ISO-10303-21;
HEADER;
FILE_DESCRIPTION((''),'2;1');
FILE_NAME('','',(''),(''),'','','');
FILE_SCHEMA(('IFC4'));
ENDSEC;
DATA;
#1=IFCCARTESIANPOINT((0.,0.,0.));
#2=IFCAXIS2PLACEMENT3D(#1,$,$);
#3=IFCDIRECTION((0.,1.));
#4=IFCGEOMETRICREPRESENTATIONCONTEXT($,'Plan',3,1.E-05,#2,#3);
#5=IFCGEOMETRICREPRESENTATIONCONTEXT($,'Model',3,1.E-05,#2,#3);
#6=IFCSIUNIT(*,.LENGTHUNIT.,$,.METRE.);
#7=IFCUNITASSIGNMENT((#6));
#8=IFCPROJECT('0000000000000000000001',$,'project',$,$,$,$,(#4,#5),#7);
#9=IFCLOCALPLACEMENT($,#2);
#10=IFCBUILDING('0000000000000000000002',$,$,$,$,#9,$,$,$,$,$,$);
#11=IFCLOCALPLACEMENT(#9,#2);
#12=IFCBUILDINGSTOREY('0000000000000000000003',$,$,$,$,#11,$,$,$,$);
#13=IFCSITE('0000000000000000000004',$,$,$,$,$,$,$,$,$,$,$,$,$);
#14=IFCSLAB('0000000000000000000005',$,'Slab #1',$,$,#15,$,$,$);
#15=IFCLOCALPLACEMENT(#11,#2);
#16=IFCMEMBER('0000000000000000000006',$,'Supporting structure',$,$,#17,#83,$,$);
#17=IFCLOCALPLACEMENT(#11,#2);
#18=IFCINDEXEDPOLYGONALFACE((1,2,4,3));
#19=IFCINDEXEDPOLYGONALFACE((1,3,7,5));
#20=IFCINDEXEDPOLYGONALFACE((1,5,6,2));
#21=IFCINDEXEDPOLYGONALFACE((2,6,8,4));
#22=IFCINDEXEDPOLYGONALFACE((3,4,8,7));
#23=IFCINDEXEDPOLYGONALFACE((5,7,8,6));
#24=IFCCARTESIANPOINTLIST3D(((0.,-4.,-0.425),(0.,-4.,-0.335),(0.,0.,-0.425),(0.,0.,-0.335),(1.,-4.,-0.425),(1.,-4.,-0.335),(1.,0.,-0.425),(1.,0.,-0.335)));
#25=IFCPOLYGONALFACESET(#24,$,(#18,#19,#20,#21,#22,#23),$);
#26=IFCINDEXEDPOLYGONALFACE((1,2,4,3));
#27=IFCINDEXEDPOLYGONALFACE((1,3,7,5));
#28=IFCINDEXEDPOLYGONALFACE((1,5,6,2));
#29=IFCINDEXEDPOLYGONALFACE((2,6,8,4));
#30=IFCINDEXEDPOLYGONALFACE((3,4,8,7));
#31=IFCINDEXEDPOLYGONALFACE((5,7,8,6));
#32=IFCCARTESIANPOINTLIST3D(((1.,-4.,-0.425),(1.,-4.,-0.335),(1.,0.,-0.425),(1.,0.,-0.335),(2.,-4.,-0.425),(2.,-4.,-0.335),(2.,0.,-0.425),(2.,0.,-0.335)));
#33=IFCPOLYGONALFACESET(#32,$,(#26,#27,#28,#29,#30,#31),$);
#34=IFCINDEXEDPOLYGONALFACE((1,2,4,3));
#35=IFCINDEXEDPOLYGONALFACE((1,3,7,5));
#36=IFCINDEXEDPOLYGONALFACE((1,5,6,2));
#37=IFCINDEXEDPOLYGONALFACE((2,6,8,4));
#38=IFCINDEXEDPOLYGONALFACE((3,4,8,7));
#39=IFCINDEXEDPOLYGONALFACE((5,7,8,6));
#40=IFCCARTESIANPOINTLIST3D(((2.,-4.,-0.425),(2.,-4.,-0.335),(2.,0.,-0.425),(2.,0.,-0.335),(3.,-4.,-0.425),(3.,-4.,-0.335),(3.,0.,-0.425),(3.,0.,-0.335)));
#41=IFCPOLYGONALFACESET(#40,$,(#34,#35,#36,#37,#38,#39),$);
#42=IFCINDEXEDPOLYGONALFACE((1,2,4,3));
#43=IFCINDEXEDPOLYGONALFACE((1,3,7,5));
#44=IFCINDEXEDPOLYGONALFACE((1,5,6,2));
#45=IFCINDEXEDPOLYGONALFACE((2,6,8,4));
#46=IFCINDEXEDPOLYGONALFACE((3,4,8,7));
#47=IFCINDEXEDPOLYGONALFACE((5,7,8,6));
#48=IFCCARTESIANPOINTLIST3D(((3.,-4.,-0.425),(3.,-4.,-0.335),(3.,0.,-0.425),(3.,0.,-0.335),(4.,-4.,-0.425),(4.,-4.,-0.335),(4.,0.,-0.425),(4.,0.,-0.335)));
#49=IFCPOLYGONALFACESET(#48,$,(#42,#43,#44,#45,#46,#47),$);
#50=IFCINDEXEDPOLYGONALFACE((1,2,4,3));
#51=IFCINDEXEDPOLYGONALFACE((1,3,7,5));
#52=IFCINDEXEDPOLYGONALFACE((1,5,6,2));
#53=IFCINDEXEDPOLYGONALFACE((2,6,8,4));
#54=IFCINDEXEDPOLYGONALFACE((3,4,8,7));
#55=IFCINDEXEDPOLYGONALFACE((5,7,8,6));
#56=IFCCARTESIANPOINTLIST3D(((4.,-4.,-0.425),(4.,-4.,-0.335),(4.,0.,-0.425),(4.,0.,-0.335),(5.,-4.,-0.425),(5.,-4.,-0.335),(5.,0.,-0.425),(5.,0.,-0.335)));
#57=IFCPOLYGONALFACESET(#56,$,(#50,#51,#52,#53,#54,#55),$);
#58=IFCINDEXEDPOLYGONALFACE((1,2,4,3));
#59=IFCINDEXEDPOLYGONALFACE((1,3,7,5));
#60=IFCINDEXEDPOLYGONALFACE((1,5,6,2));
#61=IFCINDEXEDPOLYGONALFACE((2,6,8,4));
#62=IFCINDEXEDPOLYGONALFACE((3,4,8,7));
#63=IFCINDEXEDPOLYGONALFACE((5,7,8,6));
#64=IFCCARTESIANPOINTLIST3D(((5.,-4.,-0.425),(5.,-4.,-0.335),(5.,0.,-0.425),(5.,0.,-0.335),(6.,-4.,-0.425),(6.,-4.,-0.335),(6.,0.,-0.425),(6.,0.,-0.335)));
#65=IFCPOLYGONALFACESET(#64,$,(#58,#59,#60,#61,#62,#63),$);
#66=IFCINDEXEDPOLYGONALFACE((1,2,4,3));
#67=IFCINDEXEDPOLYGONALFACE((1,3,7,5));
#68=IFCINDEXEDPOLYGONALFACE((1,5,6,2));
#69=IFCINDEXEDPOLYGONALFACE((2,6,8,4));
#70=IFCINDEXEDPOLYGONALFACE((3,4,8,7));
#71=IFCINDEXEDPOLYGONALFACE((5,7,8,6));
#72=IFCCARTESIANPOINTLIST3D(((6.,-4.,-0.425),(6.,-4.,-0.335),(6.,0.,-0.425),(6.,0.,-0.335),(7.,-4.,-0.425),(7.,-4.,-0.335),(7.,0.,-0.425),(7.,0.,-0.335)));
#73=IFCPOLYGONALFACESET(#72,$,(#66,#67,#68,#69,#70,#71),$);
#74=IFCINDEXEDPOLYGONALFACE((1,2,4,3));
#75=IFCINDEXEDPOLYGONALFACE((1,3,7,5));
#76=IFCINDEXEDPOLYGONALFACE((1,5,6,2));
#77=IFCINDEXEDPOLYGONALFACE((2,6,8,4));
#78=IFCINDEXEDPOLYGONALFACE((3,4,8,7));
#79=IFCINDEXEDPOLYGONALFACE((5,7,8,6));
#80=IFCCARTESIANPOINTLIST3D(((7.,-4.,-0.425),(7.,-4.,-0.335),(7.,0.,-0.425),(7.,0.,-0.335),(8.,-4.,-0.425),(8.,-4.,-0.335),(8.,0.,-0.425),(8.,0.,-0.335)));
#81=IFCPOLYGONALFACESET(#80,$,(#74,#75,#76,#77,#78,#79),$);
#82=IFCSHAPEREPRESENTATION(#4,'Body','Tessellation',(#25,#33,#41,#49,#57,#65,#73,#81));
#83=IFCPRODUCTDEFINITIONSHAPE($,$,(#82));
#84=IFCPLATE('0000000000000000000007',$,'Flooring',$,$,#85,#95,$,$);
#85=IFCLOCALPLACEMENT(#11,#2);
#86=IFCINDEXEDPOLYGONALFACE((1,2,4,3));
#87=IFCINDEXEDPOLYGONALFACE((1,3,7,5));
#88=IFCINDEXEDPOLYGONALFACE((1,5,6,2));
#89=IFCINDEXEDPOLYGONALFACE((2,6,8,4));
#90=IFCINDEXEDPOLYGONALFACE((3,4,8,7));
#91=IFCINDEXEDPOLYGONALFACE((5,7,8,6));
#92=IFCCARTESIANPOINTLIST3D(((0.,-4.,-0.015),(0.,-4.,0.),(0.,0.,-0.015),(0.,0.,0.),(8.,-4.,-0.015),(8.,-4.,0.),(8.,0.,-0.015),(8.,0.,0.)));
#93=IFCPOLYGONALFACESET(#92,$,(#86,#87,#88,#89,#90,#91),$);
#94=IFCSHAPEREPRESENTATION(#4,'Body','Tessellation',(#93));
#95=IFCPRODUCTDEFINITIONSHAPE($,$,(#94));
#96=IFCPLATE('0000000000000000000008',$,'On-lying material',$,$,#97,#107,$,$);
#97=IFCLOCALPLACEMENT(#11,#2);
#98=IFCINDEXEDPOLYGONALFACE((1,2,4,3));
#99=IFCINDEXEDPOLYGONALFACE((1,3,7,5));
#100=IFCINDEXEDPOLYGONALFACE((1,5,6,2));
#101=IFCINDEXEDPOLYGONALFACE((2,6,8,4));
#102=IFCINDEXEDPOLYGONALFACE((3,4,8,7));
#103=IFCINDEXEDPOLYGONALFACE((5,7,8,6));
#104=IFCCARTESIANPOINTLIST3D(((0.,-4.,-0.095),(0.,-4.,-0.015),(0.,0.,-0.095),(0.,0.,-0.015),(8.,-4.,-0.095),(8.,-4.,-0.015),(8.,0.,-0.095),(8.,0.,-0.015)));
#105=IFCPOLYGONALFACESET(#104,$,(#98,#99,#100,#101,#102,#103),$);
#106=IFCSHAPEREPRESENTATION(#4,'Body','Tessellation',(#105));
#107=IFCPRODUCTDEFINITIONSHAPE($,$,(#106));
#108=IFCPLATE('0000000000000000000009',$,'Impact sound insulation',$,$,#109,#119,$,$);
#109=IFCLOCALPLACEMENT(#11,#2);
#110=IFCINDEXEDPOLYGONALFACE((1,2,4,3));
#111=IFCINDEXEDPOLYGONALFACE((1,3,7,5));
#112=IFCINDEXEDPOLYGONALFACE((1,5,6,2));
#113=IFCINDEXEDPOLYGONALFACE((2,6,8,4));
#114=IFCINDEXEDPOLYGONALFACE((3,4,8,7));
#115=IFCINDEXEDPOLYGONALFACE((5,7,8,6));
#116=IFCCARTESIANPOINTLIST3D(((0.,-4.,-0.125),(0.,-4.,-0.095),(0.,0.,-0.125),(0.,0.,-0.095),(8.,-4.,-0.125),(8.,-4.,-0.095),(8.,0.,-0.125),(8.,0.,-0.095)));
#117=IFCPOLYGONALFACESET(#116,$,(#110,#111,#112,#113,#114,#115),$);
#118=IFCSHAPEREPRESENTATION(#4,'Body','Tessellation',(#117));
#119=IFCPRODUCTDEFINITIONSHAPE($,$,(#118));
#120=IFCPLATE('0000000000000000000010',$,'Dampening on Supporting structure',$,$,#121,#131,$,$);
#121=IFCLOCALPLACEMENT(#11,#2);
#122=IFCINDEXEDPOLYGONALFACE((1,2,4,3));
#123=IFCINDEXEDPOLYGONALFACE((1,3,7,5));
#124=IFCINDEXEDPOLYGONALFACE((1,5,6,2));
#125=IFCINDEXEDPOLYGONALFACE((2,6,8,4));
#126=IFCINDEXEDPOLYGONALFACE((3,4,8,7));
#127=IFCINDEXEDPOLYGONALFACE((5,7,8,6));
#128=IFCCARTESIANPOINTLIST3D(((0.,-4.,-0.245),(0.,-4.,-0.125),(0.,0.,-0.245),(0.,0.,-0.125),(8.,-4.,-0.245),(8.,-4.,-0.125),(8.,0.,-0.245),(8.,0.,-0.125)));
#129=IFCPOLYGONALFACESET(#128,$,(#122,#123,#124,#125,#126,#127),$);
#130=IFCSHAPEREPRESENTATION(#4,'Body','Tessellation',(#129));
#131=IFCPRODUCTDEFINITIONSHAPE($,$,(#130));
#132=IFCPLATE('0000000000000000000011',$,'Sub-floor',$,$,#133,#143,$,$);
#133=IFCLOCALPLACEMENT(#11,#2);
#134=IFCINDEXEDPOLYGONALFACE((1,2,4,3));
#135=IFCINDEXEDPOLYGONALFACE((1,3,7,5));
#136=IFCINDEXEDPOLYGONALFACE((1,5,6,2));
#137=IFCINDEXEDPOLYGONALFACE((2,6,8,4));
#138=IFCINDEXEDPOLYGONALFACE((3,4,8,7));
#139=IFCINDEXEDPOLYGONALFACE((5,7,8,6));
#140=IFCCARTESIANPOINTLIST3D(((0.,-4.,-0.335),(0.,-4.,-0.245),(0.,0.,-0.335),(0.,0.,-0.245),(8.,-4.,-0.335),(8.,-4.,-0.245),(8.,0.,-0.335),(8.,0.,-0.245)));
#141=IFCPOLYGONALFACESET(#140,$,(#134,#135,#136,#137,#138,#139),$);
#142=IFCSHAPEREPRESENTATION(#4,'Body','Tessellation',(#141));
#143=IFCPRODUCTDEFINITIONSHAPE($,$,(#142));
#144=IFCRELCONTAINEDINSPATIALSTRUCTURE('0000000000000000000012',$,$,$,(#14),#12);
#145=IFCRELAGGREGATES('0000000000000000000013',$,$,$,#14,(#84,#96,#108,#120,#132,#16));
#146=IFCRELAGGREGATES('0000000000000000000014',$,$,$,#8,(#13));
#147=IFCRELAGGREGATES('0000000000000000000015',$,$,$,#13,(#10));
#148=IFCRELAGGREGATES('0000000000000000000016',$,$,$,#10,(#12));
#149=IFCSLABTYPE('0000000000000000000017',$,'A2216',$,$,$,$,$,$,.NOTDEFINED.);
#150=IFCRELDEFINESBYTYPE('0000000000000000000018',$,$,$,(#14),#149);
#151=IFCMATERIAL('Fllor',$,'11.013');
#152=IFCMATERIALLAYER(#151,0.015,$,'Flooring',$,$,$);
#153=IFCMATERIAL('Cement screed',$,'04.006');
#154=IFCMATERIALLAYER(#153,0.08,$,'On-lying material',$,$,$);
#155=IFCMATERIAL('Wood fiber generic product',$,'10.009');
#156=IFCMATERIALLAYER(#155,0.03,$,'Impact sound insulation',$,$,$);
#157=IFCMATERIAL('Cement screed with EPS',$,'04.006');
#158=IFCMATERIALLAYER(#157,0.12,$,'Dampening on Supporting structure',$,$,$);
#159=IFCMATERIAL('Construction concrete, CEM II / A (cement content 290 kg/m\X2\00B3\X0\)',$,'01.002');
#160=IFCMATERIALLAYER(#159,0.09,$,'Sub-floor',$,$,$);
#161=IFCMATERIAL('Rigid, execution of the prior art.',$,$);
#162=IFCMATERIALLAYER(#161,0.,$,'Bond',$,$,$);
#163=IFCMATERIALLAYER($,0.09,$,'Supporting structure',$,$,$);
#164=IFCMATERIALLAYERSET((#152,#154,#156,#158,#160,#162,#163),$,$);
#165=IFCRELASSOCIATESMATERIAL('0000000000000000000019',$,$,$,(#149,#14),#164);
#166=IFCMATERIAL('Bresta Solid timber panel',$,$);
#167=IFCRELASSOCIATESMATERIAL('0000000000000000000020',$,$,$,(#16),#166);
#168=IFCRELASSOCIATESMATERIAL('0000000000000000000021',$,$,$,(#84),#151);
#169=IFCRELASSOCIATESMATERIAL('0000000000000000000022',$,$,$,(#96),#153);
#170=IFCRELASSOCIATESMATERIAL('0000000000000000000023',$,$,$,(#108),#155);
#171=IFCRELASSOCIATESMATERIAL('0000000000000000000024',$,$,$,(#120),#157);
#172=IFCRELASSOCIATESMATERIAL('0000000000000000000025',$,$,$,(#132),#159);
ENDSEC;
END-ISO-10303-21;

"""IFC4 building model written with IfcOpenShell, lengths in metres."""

from ifc_helpers import new_model, si_unit, direction, frame, frame_2d, origin, origin_with_axes, place, context, project, spatial, rectangle, extrude, material, layer, layer_set, type_object, element, aggregate, save


model = new_model("IFC4")

# Units and contexts
plan_context = context("Plan", 3, precision=1e-05, world=origin(), true_north=direction((0.0, 1.0)))
model_context = context("Model", 3, precision=1e-05, world=origin(), true_north=direction((0.0, 1.0)))
ifc_project = project(units=[si_unit("LENGTHUNIT", "METRE")], contexts=[plan_context, model_context])

# Site, building, storey
site = spatial("IfcSite", under=ifc_project)
building_placement = place(None, origin())
building = spatial("IfcBuilding", under=site, at=building_placement)
storey_placement = place(building_placement, origin())
storey = spatial("IfcBuildingStorey", under=building, at=storey_placement)

# Slab, member, plates
ifc_material_1 = material(Name="Fllor", Category="11.013")
ifc_layer_1 = layer(ifc_material_1, 0.015, Name="Flooring")
ifc_material_2 = material(Name="Cement screed", Category="04.006")
ifc_layer_2 = layer(ifc_material_2, 0.08, Name="On-lying material")
ifc_material_3 = material(Name="Wood fiber generic product", Category="10.009")
ifc_layer_3 = layer(ifc_material_3, 0.03, Name="Impact sound insulation")
ifc_material_4 = material(Name="Cement screed with EPS", Category="04.006")
ifc_layer_4 = layer(ifc_material_4, 0.12, Name="Dampening on Supporting structure")
ifc_material_5 = material(Name="Construction concrete, CEM II / A (cement content 290 kg/m³)", Category="01.002")
ifc_layer_5 = layer(ifc_material_5, 0.09, Name="Sub-floor")
ifc_material_6 = material(Name="Rigid, execution of the prior art.")
ifc_layer_6 = layer(ifc_material_6, 0.0, Name="Bond")
ifc_layer_7 = layer(None, 0.09, Name="Supporting structure")
ifc_layer_set = layer_set([ifc_layer_1, ifc_layer_2, ifc_layer_3, ifc_layer_4, ifc_layer_5, ifc_layer_6, ifc_layer_7])
slab_type = type_object("IfcSlabType", Name="A2216", PredefinedType="NOTDEFINED", material=ifc_layer_set)
slab_placement = place(None, frame((0.0, 0.0, 0.0), z_axis=(0.0, 0.0, -1.0), x_axis=(1.0, 0.0, 0.0)))
slab = element("IfcSlab", 1, at=slab_placement, inside=storey, type_object=slab_type, material=ifc_layer_set, Name="Slab #1")
ifc_material_7 = material(Name="Bresta Solid timber panel")
member_placement = place(slab_placement, origin())
member = element("IfcMember", 2, at=member_placement, material=ifc_material_7, Name="Supporting structure", context=plan_context, shape_type="SweptSolid", body=[
    extrude(rectangle(XDim=1.0, YDim=0.09, at=frame_2d((0.5, 0.045), x_axis=(1.0, 0.0))), frame((0.0, 4.0, 0.335), z_axis=(0.0, -1.0, 0.0), x_axis=(1.0, 0.0, 0.0)), (0.0, 0.0, 1.0), 4.0),
    extrude(rectangle(XDim=1.0, YDim=0.09, at=frame_2d((0.5, 0.045), x_axis=(1.0, 0.0))), frame((1.0, 4.0, 0.335), z_axis=(0.0, -1.0, 0.0), x_axis=(1.0, 0.0, 0.0)), (0.0, 0.0, 1.0), 4.0),
    extrude(rectangle(XDim=1.0, YDim=0.09, at=frame_2d((0.5, 0.045), x_axis=(1.0, 0.0))), frame((2.0, 4.0, 0.335), z_axis=(0.0, -1.0, 0.0), x_axis=(1.0, 0.0, 0.0)), (0.0, 0.0, 1.0), 4.0),
    extrude(rectangle(XDim=1.0, YDim=0.09, at=frame_2d((0.5, 0.045), x_axis=(1.0, 0.0))), frame((3.0, 4.0, 0.335), z_axis=(0.0, -1.0, 0.0), x_axis=(1.0, 0.0, 0.0)), (0.0, 0.0, 1.0), 4.0),
    extrude(rectangle(XDim=1.0, YDim=0.09, at=frame_2d((0.5, 0.045), x_axis=(1.0, 0.0))), frame((4.0, 4.0, 0.335), z_axis=(0.0, -1.0, 0.0), x_axis=(1.0, 0.0, 0.0)), (0.0, 0.0, 1.0), 4.0),
    extrude(rectangle(XDim=1.0, YDim=0.09, at=frame_2d((0.5, 0.045), x_axis=(1.0, 0.0))), frame((5.0, 4.0, 0.335), z_axis=(0.0, -1.0, 0.0), x_axis=(1.0, 0.0, 0.0)), (0.0, 0.0, 1.0), 4.0),
    extrude(rectangle(XDim=1.0, YDim=0.09, at=frame_2d((0.5, 0.045), x_axis=(1.0, 0.0))), frame((6.0, 4.0, 0.335), z_axis=(0.0, -1.0, 0.0), x_axis=(1.0, 0.0, 0.0)), (0.0, 0.0, 1.0), 4.0),
    extrude(rectangle(XDim=1.0, YDim=0.09, at=frame_2d((0.5, 0.045), x_axis=(1.0, 0.0))), frame((7.0, 4.0, 0.335), z_axis=(0.0, -1.0, 0.0), x_axis=(1.0, 0.0, 0.0)), (0.0, 0.0, 1.0), 4.0),
])
plate_1_placement = place(slab_placement, origin())
plate_1 = element("IfcPlate", 3, at=plate_1_placement, material=ifc_material_1, Name="Flooring", context=plan_context, shape_type="SweptSolid", body=[
    extrude(rectangle(XDim=8.0, YDim=4.0, at=frame_2d((4.0, 2.0), x_axis=(1.0, 0.0))), origin_with_axes(), (0.0, 0.0, 1.0), 0.015),
])
plate_2_placement = place(slab_placement, origin())
plate_2 = element("IfcPlate", 4, at=plate_2_placement, material=ifc_material_2, Name="On-lying material", context=plan_context, shape_type="SweptSolid", body=[
    extrude(rectangle(XDim=8.0, YDim=4.0, at=frame_2d((4.0, 2.0), x_axis=(1.0, 0.0))), frame((0.0, 0.0, 0.015), z_axis=(0.0, 0.0, 1.0), x_axis=(1.0, 0.0, 0.0)), (0.0, 0.0, 1.0), 0.08),
])
plate_3_placement = place(slab_placement, origin())
plate_3 = element("IfcPlate", 5, at=plate_3_placement, material=ifc_material_3, Name="Impact sound insulation", context=plan_context, shape_type="SweptSolid", body=[
    extrude(rectangle(XDim=8.0, YDim=4.0, at=frame_2d((4.0, 2.0), x_axis=(1.0, 0.0))), frame((0.0, 0.0, 0.095), z_axis=(0.0, 0.0, 1.0), x_axis=(1.0, 0.0, 0.0)), (0.0, 0.0, 1.0), 0.03),
])
plate_4_placement = place(slab_placement, origin())
plate_4 = element("IfcPlate", 6, at=plate_4_placement, material=ifc_material_4, Name="Dampening on Supporting structure", context=plan_context, shape_type="SweptSolid", body=[
    extrude(rectangle(XDim=8.0, YDim=4.0, at=frame_2d((4.0, 2.0), x_axis=(1.0, 0.0))), frame((0.0, 0.0, 0.125), z_axis=(0.0, 0.0, 1.0), x_axis=(1.0, 0.0, 0.0)), (0.0, 0.0, 1.0), 0.12),
])
plate_5_placement = place(slab_placement, origin())
plate_5 = element("IfcPlate", 7, at=plate_5_placement, material=ifc_material_5, Name="Sub-floor", context=plan_context, shape_type="SweptSolid", body=[
    extrude(rectangle(XDim=8.0, YDim=4.0, at=frame_2d((4.0, 2.0), x_axis=(1.0, 0.0))), frame((0.0, 0.0, 0.245), z_axis=(0.0, 0.0, 1.0), x_axis=(1.0, 0.0, 0.0)), (0.0, 0.0, 1.0), 0.09),
])
aggregate(slab, [plate_1, plate_2, plate_3, plate_4, plate_5, member])

save(model, "model.ifc")
